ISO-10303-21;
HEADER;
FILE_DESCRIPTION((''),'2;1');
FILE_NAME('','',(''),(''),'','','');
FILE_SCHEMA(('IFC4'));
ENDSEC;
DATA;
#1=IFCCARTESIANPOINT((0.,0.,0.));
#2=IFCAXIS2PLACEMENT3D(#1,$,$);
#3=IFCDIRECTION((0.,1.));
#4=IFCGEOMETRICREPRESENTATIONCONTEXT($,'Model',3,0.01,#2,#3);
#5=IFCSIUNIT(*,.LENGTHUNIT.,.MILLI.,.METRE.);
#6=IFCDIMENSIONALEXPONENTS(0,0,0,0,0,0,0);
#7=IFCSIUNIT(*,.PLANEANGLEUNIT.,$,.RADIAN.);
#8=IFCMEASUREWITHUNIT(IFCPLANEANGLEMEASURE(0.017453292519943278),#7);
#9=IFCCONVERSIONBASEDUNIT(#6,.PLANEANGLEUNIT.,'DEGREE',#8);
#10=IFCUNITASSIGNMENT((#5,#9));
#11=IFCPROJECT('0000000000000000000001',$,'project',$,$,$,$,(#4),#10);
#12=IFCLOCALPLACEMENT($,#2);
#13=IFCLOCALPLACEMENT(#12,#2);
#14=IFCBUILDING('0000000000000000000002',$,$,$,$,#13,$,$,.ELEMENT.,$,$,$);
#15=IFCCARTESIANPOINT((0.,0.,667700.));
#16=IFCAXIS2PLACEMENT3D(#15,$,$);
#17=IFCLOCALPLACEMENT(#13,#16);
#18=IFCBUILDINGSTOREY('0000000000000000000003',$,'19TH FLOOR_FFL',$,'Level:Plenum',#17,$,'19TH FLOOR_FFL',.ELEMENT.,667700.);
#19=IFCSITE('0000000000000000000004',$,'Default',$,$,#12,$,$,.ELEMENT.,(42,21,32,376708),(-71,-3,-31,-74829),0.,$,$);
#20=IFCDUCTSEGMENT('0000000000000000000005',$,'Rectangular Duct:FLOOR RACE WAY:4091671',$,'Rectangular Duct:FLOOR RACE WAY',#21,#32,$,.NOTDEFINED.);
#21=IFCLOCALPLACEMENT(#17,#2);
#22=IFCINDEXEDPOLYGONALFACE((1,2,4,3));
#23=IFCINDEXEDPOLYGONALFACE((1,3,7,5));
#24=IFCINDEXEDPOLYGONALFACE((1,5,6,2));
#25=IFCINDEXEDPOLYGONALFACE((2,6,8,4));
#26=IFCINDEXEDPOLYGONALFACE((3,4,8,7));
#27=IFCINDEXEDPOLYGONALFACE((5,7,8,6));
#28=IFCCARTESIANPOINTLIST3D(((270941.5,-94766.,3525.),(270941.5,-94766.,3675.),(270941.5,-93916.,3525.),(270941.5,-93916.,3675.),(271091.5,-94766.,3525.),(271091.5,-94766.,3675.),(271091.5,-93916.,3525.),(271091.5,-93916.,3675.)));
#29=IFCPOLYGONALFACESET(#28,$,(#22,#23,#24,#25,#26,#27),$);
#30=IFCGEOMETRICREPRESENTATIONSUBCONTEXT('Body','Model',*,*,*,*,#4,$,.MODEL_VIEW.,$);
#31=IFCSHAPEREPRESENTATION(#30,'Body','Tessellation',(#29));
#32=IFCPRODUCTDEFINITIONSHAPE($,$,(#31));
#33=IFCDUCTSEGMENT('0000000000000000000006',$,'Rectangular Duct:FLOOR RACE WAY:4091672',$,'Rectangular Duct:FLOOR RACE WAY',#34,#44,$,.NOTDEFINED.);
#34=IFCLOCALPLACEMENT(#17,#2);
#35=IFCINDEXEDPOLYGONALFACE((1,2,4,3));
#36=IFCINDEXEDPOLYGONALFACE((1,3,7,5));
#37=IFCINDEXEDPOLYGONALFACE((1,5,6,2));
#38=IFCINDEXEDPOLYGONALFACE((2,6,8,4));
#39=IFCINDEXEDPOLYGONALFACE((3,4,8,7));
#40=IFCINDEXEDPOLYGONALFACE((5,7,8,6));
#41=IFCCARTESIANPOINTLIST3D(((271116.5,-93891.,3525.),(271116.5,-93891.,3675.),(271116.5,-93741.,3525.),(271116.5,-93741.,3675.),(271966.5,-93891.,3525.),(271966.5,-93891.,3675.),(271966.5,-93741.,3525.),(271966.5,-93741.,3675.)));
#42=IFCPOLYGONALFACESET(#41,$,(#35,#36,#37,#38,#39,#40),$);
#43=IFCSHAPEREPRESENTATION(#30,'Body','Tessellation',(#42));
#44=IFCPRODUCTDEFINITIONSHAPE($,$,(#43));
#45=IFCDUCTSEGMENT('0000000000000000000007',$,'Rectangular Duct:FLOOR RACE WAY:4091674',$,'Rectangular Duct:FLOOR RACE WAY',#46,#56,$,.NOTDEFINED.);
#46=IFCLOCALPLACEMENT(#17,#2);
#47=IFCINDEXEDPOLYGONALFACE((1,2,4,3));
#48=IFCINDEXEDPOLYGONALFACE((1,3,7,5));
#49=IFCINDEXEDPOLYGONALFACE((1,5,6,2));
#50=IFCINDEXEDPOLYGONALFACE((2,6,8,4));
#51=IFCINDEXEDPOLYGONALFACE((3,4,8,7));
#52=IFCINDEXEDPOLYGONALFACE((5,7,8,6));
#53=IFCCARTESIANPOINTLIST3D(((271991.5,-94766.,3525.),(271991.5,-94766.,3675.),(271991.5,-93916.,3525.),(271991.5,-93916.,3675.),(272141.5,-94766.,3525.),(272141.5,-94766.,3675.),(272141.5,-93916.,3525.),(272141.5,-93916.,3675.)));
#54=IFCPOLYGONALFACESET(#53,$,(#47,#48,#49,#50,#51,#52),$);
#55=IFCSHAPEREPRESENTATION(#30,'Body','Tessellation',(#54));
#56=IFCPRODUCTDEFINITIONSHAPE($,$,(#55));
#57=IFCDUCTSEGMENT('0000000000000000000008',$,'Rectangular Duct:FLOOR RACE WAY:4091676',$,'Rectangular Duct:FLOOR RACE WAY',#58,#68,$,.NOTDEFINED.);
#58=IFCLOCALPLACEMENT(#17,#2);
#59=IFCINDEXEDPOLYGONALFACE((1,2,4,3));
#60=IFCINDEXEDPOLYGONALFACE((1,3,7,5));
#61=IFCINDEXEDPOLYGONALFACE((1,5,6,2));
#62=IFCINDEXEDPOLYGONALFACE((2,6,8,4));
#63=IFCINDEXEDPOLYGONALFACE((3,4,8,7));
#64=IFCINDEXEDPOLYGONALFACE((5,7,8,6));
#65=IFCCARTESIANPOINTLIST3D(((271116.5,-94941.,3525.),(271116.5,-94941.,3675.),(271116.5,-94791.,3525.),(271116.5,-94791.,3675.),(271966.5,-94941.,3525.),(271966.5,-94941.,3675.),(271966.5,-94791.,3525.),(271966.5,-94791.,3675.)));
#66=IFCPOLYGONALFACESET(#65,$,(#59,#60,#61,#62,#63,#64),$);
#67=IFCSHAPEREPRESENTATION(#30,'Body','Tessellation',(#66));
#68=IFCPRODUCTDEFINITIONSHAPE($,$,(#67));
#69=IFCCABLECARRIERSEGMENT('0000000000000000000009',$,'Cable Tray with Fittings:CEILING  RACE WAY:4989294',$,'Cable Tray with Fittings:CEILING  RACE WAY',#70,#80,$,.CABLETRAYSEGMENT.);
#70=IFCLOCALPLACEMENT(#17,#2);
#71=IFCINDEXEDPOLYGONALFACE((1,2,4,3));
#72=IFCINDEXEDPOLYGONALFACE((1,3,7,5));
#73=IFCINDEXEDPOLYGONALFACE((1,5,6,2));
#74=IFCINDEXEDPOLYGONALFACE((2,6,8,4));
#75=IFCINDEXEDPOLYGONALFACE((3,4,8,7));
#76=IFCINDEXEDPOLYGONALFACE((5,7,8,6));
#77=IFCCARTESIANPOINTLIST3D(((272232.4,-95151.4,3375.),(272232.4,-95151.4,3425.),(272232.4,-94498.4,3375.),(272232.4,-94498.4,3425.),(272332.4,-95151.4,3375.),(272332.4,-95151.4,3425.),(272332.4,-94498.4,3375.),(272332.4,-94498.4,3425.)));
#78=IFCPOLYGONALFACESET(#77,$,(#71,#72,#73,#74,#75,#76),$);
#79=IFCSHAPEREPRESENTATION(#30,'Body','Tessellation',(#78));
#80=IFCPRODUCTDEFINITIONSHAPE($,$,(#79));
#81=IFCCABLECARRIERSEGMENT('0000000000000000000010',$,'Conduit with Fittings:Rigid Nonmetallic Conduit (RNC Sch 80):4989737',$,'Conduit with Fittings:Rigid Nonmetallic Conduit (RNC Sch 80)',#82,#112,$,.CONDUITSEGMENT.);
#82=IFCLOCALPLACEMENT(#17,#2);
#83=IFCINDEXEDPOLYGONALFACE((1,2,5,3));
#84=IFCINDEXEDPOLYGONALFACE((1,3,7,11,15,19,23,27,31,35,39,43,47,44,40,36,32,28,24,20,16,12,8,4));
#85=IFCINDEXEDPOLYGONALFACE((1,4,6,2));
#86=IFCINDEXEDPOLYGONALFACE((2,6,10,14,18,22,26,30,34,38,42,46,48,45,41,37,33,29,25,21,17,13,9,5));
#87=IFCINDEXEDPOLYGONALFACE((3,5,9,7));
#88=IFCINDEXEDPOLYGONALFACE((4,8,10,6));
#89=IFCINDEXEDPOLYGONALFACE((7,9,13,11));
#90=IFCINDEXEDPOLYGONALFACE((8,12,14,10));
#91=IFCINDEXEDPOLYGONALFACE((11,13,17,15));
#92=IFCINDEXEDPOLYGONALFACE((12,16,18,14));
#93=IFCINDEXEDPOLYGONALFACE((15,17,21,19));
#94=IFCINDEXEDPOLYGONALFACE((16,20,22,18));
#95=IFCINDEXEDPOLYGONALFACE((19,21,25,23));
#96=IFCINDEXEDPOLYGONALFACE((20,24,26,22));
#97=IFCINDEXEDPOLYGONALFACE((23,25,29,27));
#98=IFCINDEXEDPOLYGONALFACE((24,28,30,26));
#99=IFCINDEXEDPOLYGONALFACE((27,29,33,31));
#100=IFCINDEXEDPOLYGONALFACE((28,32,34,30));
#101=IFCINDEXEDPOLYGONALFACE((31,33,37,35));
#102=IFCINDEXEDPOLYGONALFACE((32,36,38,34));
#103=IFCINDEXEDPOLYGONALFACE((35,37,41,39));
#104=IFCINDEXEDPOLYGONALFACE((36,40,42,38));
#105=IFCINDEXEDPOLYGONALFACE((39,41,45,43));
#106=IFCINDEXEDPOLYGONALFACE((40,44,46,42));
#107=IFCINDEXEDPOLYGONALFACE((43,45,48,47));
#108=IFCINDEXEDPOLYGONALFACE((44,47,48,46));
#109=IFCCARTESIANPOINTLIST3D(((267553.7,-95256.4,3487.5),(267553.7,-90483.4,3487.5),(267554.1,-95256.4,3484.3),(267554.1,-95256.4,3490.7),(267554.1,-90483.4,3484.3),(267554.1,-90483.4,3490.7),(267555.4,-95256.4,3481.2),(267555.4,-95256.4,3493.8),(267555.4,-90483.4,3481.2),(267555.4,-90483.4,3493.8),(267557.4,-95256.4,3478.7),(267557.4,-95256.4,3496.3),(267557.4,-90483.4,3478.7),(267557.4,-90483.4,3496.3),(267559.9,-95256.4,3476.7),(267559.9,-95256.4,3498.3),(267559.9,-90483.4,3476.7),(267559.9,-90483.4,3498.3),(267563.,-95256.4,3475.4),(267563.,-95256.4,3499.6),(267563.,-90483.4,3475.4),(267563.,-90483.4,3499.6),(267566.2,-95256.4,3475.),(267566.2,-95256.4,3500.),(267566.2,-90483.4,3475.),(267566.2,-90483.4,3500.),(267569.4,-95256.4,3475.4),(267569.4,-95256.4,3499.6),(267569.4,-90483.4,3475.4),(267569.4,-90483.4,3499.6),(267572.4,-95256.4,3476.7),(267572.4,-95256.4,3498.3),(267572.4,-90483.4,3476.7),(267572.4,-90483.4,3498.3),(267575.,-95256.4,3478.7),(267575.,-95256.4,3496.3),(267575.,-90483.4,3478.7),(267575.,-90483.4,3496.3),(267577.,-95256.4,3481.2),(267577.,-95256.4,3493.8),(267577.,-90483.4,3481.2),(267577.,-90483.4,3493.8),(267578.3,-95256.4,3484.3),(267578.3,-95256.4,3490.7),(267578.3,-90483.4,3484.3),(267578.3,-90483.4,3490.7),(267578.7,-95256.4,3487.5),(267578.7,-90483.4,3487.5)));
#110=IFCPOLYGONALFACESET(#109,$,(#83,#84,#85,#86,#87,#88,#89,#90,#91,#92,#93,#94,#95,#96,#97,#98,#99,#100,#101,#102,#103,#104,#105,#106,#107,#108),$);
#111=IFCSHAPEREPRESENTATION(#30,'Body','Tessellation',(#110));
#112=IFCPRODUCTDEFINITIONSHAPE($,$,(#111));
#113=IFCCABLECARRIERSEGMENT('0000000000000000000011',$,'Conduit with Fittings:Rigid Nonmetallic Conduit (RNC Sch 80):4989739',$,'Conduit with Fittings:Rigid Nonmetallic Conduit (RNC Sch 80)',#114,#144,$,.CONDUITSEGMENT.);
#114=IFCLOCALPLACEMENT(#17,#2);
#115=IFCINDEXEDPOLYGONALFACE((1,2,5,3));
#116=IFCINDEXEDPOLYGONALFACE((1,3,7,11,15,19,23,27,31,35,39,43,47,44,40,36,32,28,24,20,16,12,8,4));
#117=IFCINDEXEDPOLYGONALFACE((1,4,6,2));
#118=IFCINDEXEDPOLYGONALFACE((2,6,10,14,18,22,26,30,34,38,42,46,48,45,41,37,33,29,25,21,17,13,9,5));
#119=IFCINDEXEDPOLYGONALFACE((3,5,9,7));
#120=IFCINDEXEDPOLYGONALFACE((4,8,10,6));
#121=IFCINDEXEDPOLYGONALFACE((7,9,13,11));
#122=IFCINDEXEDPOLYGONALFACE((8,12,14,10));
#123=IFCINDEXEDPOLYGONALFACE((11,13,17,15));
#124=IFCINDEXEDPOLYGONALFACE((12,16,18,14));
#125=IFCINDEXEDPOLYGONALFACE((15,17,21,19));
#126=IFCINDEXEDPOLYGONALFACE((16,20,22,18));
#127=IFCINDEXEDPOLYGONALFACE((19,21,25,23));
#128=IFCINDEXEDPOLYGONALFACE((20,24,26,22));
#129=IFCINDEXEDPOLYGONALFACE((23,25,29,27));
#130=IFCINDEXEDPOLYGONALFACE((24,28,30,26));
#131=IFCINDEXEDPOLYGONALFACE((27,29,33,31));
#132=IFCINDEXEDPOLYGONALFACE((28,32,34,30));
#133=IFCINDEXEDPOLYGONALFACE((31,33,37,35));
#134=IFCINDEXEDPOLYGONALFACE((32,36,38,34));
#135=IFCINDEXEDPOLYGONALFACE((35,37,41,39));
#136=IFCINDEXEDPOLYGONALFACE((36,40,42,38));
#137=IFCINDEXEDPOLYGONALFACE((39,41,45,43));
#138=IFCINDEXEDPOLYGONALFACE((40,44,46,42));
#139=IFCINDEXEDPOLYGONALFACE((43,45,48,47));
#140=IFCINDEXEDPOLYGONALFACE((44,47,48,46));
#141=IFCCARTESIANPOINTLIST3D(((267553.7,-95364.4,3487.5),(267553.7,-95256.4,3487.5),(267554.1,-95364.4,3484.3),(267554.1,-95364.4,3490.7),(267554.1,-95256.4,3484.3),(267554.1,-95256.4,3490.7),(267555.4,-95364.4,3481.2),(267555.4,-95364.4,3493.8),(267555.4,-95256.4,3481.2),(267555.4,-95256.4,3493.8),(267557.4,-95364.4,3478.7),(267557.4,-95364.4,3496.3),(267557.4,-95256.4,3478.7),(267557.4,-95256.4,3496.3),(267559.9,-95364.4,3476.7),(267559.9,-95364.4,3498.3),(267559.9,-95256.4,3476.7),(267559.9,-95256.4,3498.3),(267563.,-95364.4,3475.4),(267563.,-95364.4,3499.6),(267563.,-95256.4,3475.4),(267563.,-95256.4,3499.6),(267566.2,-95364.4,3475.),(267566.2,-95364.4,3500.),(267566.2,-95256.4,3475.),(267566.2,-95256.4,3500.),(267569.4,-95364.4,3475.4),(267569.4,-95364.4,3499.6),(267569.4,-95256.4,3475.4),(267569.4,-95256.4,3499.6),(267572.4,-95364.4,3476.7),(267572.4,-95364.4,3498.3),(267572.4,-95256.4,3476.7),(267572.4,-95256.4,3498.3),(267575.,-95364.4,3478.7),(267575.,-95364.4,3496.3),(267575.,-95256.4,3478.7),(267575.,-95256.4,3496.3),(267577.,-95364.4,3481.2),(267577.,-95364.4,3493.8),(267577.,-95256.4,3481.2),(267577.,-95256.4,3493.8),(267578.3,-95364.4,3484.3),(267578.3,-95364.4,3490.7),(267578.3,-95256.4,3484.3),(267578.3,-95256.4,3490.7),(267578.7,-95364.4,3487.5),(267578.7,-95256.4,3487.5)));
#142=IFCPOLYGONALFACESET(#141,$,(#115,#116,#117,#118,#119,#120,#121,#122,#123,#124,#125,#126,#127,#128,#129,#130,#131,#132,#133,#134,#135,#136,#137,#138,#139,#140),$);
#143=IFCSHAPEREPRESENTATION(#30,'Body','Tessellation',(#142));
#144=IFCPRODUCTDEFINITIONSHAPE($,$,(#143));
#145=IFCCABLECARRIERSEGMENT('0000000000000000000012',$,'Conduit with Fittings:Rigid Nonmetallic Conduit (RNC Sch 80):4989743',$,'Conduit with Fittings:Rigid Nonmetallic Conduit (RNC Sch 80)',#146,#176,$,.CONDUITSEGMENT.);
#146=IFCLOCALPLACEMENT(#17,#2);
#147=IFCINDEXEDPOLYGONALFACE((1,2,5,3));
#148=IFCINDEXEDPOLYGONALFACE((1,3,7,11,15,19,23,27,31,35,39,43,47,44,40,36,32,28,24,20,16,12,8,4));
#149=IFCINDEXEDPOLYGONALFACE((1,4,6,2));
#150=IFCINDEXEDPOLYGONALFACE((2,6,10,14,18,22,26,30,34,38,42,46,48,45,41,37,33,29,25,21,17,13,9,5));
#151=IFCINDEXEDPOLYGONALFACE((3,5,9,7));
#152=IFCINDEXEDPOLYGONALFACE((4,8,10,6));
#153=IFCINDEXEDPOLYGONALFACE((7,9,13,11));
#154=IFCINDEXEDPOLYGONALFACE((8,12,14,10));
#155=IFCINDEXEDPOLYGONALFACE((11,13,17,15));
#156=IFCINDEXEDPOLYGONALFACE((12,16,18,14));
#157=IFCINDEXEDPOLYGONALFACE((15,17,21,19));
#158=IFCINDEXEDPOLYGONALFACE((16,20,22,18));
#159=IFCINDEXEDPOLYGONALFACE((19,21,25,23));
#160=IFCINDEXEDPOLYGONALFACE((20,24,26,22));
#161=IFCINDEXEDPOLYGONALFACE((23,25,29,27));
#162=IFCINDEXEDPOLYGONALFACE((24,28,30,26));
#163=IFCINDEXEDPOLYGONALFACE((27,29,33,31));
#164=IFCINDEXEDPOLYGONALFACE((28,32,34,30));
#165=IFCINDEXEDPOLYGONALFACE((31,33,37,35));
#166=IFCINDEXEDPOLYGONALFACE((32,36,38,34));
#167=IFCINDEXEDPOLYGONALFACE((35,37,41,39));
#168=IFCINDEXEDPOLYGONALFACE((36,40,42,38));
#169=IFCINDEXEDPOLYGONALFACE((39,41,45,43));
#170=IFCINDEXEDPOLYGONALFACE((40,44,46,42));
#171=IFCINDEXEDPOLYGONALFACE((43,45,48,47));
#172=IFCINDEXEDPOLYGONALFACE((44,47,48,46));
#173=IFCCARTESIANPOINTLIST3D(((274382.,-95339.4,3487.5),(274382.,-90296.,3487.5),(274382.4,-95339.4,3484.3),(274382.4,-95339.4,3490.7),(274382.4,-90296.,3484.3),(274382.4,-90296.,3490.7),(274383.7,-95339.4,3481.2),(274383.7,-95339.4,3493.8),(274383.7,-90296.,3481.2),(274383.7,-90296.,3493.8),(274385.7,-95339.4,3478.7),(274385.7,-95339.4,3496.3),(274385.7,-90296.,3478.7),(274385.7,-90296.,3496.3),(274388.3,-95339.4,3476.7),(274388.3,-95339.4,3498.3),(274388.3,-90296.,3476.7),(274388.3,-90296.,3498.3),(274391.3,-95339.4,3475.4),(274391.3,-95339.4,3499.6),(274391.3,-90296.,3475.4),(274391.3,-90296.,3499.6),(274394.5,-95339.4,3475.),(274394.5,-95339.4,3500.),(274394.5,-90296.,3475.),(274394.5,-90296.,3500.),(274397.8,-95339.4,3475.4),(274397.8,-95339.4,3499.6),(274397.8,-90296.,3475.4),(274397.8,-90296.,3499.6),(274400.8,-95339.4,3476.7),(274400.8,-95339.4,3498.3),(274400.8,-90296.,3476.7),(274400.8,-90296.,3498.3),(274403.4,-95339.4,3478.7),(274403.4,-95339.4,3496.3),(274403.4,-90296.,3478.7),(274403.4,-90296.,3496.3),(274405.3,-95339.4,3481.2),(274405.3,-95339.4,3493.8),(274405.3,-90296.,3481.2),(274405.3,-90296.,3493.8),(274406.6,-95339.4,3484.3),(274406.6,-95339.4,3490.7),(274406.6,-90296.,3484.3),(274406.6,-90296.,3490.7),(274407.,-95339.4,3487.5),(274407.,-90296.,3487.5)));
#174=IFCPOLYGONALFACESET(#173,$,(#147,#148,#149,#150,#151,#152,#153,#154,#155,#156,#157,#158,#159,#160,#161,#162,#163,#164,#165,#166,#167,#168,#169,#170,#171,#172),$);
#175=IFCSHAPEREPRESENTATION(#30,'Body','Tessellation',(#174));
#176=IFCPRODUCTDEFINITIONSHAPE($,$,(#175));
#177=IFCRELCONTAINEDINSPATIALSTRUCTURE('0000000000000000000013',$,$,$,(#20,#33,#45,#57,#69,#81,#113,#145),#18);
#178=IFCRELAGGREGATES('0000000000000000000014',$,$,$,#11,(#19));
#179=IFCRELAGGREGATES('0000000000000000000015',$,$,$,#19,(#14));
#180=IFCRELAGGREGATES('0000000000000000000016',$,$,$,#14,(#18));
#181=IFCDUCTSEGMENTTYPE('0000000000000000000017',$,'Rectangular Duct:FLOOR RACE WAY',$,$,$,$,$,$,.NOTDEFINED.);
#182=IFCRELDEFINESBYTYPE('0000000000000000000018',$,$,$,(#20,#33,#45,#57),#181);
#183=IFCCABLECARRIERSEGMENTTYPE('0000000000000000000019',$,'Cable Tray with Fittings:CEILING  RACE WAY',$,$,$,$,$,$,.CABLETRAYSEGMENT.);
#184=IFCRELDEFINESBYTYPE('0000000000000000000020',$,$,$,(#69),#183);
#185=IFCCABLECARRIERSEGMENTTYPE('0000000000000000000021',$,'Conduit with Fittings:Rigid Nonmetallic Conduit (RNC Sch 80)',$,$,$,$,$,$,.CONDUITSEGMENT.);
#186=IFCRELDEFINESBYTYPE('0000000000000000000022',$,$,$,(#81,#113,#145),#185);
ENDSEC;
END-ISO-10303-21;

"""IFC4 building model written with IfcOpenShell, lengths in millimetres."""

from ifc_helpers import new_model, entity, si_unit, converted_unit, direction, frame, origin, place, context, subcontext, project, spatial, arc, indexed_curve, outline, extrude, type_object, element, save


model = new_model("IFC4")

# Units and contexts
model_context = context("Model", 3, precision=0.01, world=origin(), true_north=direction((0.0, 1.0)))
body_context = subcontext(model_context, "Body", "Model", "MODEL_VIEW")
ifc_project = project(units=[si_unit("LENGTHUNIT", "METRE", prefix="MILLI"), converted_unit("PLANEANGLEUNIT", "DEGREE", entity("IfcPlaneAngleMeasure", 0.017453292519943278), si_unit("PLANEANGLEUNIT", "RADIAN"), dimensions=[0, 0, 0, 0, 0, 0, 0])], contexts=[model_context])

# Site, building, storey
site_placement = place(None, origin())
site = spatial("IfcSite", under=ifc_project, at=site_placement, Name="Default", CompositionType="ELEMENT", RefLatitude=(42, 21, 32, 376708), RefLongitude=(-71, -3, -31, -74829), RefElevation=0.0)
building_placement = place(site_placement, origin())
building = spatial("IfcBuilding", under=site, at=building_placement, CompositionType="ELEMENT")
storey_placement = place(building_placement, frame((0.0, 0.0, 667700.0)))
storey = spatial("IfcBuildingStorey", under=building, at=storey_placement, Name="19TH FLOOR_FFL", ObjectType="Level:Plenum", LongName="19TH FLOOR_FFL", CompositionType="ELEMENT", Elevation=667700.0)

# Duct segments
duct_segment_type_1 = type_object("IfcDuctSegmentType", Name="Rectangular Duct:FLOOR RACE WAY", PredefinedType="NOTDEFINED")
duct_segment_1_placement = place(storey_placement, origin())
element("IfcDuctSegment", 1, at=duct_segment_1_placement, inside=storey, type_object=duct_segment_type_1, Name="Rectangular Duct:FLOOR RACE WAY:4091671", ObjectType="Rectangular Duct:FLOOR RACE WAY", PredefinedType="NOTDEFINED", context=body_context, shape_type="SweptSolid", body=[
    extrude(outline(indexed_curve([(-425.0, -75.0), (425.0, -75.0), (425.0, 75.0), (-425.0, 75.0), (-425.0, -75.0)], self_intersect=False)), frame((271016.5, -94341.0, 3525.0), z_axis=(0.0, 0.0, 1.0), x_axis=(0.0, -1.0, 0.0)), (0.0, 0.0, 1.0), 150.0),
])
duct_segment_2_placement = place(storey_placement, origin())
element("IfcDuctSegment", 2, at=duct_segment_2_placement, inside=storey, type_object=duct_segment_type_1, Name="Rectangular Duct:FLOOR RACE WAY:4091672", ObjectType="Rectangular Duct:FLOOR RACE WAY", PredefinedType="NOTDEFINED", context=body_context, shape_type="SweptSolid", body=[
    extrude(outline(indexed_curve([(-425.0, -75.0), (425.0, -75.0), (425.0, 75.0), (-425.0, 75.0), (-425.0, -75.0)], self_intersect=False)), frame((271541.5, -93816.0, 3525.0)), (0.0, 0.0, 1.0), 150.0),
])
duct_segment_3_placement = place(storey_placement, origin())
element("IfcDuctSegment", 3, at=duct_segment_3_placement, inside=storey, type_object=duct_segment_type_1, Name="Rectangular Duct:FLOOR RACE WAY:4091674", ObjectType="Rectangular Duct:FLOOR RACE WAY", PredefinedType="NOTDEFINED", context=body_context, shape_type="SweptSolid", body=[
    extrude(outline(indexed_curve([(-425.0, -75.0), (425.0, -75.0), (425.0, 75.0), (-425.0, 75.0), (-425.0, -75.0)], self_intersect=False)), frame((272066.5, -94341.0, 3525.0), z_axis=(0.0, 0.0, 1.0), x_axis=(0.0, -1.0, 0.0)), (0.0, 0.0, 1.0), 150.0),
])
duct_segment_4_placement = place(storey_placement, origin())
element("IfcDuctSegment", 4, at=duct_segment_4_placement, inside=storey, type_object=duct_segment_type_1, Name="Rectangular Duct:FLOOR RACE WAY:4091676", ObjectType="Rectangular Duct:FLOOR RACE WAY", PredefinedType="NOTDEFINED", context=body_context, shape_type="SweptSolid", body=[
    extrude(outline(indexed_curve([(-425.0, -75.0), (425.0, -75.0), (425.0, 75.0), (-425.0, 75.0), (-425.0, -75.0)], self_intersect=False)), frame((271541.5, -94866.0, 3525.0), z_axis=(0.0, 0.0, 1.0), x_axis=(-1.0, 0.0, 0.0)), (0.0, 0.0, 1.0), 150.0),
])

# Cable carrier segments
cable_carrier_segment_type_1 = type_object("IfcCableCarrierSegmentType", Name="Cable Tray with Fittings:CEILING  RACE WAY", PredefinedType="CABLETRAYSEGMENT")
cable_carrier_segment_1_placement = place(storey_placement, origin())
element("IfcCableCarrierSegment", 5, at=cable_carrier_segment_1_placement, inside=storey, type_object=cable_carrier_segment_type_1, Name="Cable Tray with Fittings:CEILING  RACE WAY:4989294", ObjectType="Cable Tray with Fittings:CEILING  RACE WAY", PredefinedType="CABLETRAYSEGMENT", context=body_context, shape_type="SweptSolid", body=[
    extrude(outline(indexed_curve([(-326.5, -50.0), (326.5, -50.0), (326.5, 50.0), (-326.5, 50.0), (-326.5, -50.0)], self_intersect=False)), frame((272282.4, -94824.9, 3375.0), z_axis=(0.0, 0.0, 1.0), x_axis=(0.0, -1.0, 0.0)), (0.0, 0.0, 1.0), 50.0),
])
cable_carrier_segment_type_2 = type_object("IfcCableCarrierSegmentType", Name="Conduit with Fittings:Rigid Nonmetallic Conduit (RNC Sch 80)", PredefinedType="CONDUITSEGMENT")
cable_carrier_segment_2_placement = place(storey_placement, origin())
element("IfcCableCarrierSegment", 6, at=cable_carrier_segment_2_placement, inside=storey, type_object=cable_carrier_segment_type_2, Name="Conduit with Fittings:Rigid Nonmetallic Conduit (RNC Sch 80):4989737", ObjectType="Conduit with Fittings:Rigid Nonmetallic Conduit (RNC Sch 80)", PredefinedType="CONDUITSEGMENT", context=body_context, shape_type="SweptSolid", body=[
    extrude(outline(indexed_curve([(12.5, 0.0), (8.8, 8.8), (0.0, 12.5), (-8.8, 8.8), (-12.5, 0.0), (-8.8, -8.8), (0.0, -12.5), (8.8, -8.8)], segments=[arc(1, 2, 3), arc(3, 4, 5), arc(5, 6, 7), arc(7, 8, 1)], self_intersect=False)), frame((267566.2, -95256.4, 3487.5), z_axis=(0.0, 1.0, 0.0), x_axis=(1.0, 0.0, 0.0)), (0.0, 0.0, 1.0), 4773.0),
])
cable_carrier_segment_3_placement = place(storey_placement, origin())
element("IfcCableCarrierSegment", 7, at=cable_carrier_segment_3_placement, inside=storey, type_object=cable_carrier_segment_type_2, Name="Conduit with Fittings:Rigid Nonmetallic Conduit (RNC Sch 80):4989739", ObjectType="Conduit with Fittings:Rigid Nonmetallic Conduit (RNC Sch 80)", PredefinedType="CONDUITSEGMENT", context=body_context, shape_type="SweptSolid", body=[
    extrude(outline(indexed_curve([(12.5, 0.0), (8.8, 8.8), (0.0, 12.5), (-8.8, 8.8), (-12.5, 0.0), (-8.8, -8.8), (0.0, -12.5), (8.8, -8.8)], segments=[arc(1, 2, 3), arc(3, 4, 5), arc(5, 6, 7), arc(7, 8, 1)], self_intersect=False)), frame((267566.2, -95364.4, 3487.5), z_axis=(0.0, 1.0, 0.0), x_axis=(1.0, 0.0, 0.0)), (0.0, 0.0, 1.0), 108.0),
])
cable_carrier_segment_4_placement = place(storey_placement, origin())
element("IfcCableCarrierSegment", 8, at=cable_carrier_segment_4_placement, inside=storey, type_object=cable_carrier_segment_type_2, Name="Conduit with Fittings:Rigid Nonmetallic Conduit (RNC Sch 80):4989743", ObjectType="Conduit with Fittings:Rigid Nonmetallic Conduit (RNC Sch 80)", PredefinedType="CONDUITSEGMENT", context=body_context, shape_type="SweptSolid", body=[
    extrude(outline(indexed_curve([(12.5, 0.0), (8.8, 8.8), (0.0, 12.5), (-8.8, 8.8), (-12.5, 0.0), (-8.8, -8.8), (0.0, -12.5), (8.8, -8.8)], segments=[arc(1, 2, 3), arc(3, 4, 5), arc(5, 6, 7), arc(7, 8, 1)], self_intersect=False)), frame((274394.5, -95339.4, 3487.5), z_axis=(0.0, 1.0, 0.0), x_axis=(-1.0, 0.0, 0.0)), (0.0, 0.0, 1.0), 5043.5),
])

save(model, "model.ifc")
